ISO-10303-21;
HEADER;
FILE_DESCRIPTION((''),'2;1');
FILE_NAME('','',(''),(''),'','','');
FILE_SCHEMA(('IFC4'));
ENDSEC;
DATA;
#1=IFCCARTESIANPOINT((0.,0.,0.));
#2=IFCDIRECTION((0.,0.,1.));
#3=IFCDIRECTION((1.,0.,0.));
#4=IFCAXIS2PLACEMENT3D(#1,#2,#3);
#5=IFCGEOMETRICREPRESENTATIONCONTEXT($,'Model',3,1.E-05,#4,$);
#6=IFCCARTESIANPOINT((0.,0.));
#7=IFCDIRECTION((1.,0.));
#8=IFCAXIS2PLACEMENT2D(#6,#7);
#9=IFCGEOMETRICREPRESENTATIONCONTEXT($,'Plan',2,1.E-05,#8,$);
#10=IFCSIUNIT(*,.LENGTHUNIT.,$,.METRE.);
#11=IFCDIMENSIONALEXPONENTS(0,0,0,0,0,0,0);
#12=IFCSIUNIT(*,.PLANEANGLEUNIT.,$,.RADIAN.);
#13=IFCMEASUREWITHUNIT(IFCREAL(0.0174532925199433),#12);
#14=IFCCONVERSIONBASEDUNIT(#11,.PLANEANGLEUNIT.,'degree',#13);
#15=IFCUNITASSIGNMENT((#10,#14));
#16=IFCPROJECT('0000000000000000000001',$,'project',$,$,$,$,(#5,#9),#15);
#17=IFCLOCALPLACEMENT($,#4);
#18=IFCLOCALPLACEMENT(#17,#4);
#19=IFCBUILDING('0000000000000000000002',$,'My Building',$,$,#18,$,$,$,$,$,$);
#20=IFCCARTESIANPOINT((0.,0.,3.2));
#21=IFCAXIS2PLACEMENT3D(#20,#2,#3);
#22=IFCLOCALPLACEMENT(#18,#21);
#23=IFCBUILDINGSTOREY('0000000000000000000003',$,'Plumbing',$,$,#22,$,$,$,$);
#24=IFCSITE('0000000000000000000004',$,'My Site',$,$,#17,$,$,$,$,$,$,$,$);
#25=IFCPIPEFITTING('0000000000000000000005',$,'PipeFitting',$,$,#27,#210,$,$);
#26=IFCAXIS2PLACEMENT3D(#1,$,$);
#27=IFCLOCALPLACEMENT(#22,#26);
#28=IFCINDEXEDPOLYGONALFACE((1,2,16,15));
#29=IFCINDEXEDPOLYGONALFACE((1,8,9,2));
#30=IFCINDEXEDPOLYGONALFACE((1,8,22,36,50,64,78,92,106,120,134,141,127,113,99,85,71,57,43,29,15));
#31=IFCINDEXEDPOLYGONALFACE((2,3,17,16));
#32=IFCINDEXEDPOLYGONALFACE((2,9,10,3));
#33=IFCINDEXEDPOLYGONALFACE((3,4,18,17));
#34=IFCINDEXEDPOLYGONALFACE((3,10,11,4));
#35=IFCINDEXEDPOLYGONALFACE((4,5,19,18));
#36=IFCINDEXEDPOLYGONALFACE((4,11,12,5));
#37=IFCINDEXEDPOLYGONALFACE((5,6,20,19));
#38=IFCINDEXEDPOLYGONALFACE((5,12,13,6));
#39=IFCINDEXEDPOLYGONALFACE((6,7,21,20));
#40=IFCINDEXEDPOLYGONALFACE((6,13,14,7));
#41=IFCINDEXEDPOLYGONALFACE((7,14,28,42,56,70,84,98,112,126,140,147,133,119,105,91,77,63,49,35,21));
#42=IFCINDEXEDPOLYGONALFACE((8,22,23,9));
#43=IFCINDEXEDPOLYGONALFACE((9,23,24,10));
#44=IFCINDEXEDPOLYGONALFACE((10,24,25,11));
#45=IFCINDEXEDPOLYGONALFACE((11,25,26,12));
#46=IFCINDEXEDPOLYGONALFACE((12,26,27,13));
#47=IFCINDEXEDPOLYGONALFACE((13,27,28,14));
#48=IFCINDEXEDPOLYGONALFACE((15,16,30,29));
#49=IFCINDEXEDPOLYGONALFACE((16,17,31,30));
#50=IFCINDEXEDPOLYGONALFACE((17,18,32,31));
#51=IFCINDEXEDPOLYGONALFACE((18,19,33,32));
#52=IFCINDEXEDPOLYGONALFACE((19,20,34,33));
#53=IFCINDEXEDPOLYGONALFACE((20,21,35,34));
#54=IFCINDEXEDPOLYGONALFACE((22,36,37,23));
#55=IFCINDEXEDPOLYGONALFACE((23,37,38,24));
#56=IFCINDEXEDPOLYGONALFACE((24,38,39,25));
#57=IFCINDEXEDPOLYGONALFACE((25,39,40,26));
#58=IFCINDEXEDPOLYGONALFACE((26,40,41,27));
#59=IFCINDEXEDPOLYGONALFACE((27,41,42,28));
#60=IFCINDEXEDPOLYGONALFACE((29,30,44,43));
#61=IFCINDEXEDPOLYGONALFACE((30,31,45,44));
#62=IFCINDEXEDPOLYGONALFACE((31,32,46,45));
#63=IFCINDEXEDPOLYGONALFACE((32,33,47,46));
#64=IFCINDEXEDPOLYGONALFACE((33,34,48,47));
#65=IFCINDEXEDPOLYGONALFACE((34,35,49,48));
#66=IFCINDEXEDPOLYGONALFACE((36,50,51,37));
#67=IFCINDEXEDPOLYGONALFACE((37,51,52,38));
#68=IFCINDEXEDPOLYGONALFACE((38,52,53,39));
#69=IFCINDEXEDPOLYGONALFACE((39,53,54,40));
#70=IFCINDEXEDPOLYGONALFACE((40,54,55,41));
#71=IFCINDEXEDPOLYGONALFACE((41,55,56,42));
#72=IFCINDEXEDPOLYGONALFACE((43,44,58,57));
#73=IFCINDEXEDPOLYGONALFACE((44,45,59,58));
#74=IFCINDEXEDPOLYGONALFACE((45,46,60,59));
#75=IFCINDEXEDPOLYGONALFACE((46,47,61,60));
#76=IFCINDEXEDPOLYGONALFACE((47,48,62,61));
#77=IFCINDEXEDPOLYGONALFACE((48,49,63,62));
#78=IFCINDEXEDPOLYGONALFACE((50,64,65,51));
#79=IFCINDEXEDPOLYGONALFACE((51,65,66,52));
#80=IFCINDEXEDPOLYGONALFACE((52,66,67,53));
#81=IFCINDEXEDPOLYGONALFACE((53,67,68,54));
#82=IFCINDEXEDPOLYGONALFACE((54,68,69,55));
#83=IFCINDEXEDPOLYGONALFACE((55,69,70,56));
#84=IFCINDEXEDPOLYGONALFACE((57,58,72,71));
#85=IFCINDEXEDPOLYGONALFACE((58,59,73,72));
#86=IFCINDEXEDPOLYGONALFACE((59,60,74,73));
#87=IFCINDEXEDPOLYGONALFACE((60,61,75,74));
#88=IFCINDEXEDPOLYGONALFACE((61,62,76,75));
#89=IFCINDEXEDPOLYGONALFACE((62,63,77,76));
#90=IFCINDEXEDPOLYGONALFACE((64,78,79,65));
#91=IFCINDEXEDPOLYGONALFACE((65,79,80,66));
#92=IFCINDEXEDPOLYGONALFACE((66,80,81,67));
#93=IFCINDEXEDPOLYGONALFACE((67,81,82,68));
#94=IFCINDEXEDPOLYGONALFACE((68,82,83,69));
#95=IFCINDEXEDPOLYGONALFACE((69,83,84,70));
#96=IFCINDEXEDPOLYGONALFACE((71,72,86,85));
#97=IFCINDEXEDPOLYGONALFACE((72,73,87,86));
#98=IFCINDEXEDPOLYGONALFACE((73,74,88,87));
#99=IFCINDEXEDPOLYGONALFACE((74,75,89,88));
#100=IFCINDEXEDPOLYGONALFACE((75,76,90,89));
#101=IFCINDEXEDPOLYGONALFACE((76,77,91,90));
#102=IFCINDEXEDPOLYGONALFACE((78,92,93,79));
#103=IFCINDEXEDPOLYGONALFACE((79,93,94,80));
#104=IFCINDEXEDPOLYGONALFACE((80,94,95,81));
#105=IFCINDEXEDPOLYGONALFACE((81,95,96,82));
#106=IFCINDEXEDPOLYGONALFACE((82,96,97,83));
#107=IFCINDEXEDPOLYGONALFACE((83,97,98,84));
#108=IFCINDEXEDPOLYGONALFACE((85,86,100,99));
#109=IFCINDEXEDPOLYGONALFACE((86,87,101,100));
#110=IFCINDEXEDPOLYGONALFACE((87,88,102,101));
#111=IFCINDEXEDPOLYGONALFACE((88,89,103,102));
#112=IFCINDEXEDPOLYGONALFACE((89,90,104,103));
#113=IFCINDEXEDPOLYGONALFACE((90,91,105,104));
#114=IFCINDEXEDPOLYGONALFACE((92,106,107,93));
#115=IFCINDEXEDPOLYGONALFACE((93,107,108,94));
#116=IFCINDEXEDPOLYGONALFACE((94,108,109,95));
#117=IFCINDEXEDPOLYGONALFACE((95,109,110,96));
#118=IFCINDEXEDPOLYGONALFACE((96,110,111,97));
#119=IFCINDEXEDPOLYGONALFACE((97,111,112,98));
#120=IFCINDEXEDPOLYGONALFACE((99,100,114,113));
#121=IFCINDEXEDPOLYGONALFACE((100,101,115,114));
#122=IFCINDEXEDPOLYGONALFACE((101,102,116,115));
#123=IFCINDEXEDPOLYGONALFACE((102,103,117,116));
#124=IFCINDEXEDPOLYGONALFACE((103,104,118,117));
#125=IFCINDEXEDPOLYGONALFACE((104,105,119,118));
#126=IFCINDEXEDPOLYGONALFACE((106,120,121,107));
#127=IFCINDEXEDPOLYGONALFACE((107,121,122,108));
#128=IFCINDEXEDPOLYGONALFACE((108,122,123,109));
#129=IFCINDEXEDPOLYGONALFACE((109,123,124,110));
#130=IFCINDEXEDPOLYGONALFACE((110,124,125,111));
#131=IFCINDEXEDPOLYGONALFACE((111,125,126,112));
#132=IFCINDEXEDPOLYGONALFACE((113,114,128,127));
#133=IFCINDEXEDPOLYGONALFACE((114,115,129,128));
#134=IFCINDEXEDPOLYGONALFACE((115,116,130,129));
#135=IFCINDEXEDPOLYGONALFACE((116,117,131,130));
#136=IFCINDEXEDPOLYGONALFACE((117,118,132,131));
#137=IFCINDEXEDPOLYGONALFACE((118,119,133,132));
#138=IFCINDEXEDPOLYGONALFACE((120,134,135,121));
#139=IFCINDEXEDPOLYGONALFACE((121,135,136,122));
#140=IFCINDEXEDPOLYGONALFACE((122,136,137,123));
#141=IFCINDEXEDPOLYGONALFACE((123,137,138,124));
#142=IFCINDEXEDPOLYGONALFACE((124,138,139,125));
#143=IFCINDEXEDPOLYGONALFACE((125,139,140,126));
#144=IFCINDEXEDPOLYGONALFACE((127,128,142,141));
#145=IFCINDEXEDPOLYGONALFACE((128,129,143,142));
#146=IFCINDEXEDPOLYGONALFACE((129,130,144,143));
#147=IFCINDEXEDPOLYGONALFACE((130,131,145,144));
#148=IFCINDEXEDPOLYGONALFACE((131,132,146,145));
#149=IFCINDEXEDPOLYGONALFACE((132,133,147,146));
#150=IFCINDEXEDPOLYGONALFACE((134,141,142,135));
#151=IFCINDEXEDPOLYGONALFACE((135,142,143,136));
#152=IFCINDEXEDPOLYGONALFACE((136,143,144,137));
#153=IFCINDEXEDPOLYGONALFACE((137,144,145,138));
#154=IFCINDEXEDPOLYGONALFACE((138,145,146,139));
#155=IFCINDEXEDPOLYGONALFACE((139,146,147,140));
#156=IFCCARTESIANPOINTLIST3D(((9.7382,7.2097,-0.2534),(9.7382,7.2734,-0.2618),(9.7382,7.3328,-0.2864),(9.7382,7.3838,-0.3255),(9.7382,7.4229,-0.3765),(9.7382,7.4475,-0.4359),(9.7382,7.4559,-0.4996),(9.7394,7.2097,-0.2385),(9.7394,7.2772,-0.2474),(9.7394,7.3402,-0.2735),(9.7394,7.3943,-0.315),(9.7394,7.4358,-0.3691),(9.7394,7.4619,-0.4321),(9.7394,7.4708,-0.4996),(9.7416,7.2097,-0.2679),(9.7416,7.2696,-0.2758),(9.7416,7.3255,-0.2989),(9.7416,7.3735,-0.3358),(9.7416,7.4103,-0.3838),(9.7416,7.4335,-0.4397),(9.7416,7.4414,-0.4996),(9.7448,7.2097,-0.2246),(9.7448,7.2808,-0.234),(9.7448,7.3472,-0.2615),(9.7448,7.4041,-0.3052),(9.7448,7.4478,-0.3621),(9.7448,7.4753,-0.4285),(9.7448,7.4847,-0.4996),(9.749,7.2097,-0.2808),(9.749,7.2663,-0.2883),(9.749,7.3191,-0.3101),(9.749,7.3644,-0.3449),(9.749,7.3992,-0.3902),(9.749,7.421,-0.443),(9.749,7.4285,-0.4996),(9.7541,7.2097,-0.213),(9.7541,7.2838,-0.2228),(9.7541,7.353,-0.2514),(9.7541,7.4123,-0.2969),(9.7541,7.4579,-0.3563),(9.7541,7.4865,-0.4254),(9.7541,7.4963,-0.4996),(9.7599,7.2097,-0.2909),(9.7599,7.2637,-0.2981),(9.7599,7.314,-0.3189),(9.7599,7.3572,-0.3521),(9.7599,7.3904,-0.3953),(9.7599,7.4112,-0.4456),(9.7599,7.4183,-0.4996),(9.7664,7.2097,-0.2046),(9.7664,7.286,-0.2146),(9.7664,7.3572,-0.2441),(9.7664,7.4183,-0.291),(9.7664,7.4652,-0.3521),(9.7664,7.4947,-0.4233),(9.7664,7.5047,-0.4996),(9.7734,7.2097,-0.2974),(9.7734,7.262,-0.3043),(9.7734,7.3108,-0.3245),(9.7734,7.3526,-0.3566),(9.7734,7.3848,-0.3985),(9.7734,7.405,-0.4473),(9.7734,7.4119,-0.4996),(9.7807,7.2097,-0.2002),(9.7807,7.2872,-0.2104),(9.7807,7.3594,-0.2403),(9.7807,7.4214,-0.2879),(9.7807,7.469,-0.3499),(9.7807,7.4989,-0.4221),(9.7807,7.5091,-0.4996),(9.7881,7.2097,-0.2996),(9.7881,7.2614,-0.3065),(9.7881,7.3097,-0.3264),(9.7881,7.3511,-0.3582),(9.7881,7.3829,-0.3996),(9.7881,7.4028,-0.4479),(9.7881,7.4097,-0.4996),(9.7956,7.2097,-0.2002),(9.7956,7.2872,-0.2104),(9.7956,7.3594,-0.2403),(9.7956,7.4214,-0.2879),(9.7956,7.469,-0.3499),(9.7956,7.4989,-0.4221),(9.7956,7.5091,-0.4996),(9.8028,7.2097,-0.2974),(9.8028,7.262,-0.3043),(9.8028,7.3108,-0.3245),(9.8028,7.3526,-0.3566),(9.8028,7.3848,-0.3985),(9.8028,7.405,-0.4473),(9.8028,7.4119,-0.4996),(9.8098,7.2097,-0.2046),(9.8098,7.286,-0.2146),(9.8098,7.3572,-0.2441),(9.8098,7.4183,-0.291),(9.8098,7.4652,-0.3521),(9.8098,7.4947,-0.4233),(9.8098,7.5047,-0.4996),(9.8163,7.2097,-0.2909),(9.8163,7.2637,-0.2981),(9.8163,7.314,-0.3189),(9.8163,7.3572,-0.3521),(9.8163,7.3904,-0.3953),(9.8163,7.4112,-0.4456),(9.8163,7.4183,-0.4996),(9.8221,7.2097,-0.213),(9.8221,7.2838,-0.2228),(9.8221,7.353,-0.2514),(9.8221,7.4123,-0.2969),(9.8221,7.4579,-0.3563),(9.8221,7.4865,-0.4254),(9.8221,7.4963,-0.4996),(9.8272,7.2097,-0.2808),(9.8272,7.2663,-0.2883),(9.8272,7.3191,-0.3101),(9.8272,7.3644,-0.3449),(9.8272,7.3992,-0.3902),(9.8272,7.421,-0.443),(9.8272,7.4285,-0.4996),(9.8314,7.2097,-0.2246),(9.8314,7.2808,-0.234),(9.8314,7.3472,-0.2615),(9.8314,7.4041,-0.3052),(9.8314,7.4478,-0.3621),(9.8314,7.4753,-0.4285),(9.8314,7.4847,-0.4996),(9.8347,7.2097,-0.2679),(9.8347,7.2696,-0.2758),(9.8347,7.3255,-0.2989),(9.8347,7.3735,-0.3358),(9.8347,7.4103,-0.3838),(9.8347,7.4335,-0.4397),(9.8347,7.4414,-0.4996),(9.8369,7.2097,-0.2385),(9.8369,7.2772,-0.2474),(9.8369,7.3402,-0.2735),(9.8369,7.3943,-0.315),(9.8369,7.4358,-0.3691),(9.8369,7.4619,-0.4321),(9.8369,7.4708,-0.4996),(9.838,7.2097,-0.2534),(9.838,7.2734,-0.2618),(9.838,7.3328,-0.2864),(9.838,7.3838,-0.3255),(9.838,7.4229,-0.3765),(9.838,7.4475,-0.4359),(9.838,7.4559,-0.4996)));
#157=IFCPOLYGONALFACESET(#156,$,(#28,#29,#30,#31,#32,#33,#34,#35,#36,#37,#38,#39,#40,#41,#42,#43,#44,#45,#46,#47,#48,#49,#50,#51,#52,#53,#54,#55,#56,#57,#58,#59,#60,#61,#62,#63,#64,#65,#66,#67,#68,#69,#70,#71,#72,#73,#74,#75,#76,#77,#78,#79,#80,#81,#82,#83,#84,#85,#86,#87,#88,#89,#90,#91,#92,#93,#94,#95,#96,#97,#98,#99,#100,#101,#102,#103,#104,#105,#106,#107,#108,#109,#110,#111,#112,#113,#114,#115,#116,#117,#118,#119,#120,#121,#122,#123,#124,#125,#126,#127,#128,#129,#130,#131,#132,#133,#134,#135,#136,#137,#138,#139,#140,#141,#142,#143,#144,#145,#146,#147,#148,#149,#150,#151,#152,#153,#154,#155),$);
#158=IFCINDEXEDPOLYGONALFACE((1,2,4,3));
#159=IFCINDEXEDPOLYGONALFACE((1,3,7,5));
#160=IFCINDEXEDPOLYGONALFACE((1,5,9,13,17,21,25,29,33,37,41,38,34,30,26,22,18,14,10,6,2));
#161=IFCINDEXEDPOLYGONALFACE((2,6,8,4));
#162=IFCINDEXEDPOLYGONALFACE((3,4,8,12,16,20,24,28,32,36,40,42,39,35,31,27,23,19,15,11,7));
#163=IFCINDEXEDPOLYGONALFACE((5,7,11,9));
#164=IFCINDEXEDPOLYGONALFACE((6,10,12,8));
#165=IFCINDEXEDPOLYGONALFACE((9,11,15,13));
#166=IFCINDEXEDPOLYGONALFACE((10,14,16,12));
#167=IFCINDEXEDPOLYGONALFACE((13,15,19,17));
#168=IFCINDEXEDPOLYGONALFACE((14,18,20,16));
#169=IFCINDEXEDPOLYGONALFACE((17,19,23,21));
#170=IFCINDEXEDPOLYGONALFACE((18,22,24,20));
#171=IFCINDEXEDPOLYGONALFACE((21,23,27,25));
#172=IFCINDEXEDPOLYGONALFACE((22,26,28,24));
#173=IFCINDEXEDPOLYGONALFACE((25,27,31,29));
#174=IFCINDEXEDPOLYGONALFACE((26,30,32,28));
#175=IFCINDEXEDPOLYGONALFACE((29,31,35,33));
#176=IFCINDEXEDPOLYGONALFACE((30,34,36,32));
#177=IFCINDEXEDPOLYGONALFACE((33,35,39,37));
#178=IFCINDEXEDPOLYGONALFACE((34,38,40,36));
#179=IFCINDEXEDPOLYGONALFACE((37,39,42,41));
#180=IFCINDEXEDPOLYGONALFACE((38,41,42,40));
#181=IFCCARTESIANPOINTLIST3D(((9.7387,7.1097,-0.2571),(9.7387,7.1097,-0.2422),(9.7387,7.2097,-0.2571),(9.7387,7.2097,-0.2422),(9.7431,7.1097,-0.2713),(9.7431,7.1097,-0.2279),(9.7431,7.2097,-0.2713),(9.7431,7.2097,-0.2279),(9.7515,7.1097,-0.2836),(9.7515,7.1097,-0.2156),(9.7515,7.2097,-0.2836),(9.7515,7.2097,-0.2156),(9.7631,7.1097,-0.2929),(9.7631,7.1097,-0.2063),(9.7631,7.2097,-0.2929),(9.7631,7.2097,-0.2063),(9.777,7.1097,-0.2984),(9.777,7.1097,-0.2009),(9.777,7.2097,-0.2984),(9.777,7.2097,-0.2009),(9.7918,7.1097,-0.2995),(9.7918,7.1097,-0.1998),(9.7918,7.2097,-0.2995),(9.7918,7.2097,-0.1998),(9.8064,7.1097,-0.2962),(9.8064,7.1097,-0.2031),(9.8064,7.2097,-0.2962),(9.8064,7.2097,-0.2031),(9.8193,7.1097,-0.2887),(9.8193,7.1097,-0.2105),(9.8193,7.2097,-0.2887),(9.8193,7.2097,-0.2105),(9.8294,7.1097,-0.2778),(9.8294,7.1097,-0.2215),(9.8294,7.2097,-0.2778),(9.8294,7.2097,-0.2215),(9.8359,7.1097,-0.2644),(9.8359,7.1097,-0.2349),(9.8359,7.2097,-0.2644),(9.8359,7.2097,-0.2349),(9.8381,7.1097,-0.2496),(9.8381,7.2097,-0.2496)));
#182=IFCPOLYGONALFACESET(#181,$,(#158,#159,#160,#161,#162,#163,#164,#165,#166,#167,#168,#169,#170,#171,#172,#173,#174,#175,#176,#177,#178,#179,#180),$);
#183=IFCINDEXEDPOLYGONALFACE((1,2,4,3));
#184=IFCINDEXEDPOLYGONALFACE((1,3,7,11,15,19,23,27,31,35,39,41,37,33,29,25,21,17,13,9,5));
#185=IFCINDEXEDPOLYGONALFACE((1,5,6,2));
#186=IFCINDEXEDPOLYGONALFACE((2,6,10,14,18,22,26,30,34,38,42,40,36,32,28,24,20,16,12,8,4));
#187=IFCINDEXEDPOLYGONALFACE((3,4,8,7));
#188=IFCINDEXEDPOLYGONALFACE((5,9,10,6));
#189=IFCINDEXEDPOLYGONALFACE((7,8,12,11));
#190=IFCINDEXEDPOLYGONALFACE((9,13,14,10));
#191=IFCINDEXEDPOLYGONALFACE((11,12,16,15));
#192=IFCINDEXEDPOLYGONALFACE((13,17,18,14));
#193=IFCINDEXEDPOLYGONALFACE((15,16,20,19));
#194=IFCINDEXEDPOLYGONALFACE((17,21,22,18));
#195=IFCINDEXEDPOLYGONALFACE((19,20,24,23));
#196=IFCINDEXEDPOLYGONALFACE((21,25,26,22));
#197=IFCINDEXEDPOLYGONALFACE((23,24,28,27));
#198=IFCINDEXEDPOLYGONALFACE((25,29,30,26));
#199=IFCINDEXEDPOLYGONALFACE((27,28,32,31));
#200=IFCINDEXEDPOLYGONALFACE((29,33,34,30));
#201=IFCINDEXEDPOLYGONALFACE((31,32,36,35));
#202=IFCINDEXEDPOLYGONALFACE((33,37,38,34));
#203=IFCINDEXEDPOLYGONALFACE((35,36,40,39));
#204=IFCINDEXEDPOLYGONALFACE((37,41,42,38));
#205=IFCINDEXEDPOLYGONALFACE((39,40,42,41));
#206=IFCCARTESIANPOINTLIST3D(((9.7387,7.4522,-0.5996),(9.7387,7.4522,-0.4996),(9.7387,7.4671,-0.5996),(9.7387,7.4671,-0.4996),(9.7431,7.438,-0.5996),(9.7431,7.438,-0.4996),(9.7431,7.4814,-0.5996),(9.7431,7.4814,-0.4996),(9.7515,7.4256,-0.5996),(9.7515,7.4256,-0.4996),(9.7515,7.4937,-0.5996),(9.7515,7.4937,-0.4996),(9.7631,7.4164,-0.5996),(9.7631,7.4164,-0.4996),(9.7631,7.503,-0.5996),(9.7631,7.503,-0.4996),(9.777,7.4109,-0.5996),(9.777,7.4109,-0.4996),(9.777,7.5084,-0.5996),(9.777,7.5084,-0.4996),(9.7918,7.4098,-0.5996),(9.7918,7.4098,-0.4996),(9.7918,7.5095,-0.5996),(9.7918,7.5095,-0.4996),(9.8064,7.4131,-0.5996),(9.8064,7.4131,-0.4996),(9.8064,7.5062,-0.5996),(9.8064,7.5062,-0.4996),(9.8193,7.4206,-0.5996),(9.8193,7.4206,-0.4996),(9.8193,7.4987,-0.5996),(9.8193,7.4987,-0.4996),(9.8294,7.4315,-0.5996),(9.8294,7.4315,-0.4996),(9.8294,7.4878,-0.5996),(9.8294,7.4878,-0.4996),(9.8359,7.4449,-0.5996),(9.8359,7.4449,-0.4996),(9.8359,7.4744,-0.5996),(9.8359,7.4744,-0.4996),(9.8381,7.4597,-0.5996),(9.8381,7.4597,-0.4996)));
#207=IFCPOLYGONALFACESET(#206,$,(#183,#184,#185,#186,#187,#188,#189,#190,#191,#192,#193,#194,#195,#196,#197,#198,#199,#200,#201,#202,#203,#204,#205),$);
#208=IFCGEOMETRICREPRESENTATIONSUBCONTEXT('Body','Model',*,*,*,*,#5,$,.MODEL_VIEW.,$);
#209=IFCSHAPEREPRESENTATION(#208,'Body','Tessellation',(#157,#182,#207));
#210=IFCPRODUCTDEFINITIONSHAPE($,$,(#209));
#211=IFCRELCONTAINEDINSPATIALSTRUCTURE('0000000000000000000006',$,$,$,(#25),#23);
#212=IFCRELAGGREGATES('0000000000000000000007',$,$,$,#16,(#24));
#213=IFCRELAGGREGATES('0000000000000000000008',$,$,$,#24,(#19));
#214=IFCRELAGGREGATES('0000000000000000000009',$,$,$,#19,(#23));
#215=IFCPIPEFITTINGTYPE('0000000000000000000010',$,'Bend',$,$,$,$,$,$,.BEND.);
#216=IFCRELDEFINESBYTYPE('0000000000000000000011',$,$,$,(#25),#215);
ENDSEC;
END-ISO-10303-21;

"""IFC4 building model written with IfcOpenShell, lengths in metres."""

from ifc_helpers import new_model, entity, si_unit, converted_unit, frame, origin_with_axes, origin_2d_with_axis, place, context, subcontext, project, spatial, circle, extrude, source, transform, mapped, type_object, type_shapes, element, save


model = new_model("IFC4")

# Units and contexts
model_context = context("Model", 3, precision=1e-05, world=origin_with_axes())
plan_context = context("Plan", 2, precision=1e-05, world=origin_2d_with_axis())
body_context = subcontext(model_context, "Body", "Model", "MODEL_VIEW")
ifc_project = project(units=[si_unit("LENGTHUNIT", "METRE"), converted_unit("PLANEANGLEUNIT", "degree", entity("IfcReal", 0.0174532925199433), si_unit("PLANEANGLEUNIT", "RADIAN"), dimensions=[0, 0, 0, 0, 0, 0, 0])], contexts=[model_context, plan_context])

# Site, building, storey
site_placement = place(None, origin_with_axes())
site = spatial("IfcSite", under=ifc_project, at=site_placement, Name="My Site")
building_placement = place(site_placement, origin_with_axes())
building = spatial("IfcBuilding", under=site, at=building_placement, Name="My Building")
storey_placement = place(building_placement, frame((0.0, 0.0, 3.2), z_axis=(0.0, 0.0, 1.0), x_axis=(1.0, 0.0, 0.0)))
storey = spatial("IfcBuildingStorey", under=building, at=storey_placement, Name="Plumbing")

# Pipe fitting
pipe_fitting_type = type_object("IfcPipeFittingType", Name="Bend", PredefinedType="BEND")
shared_shape = source(origin_with_axes(), body_context, "Body", "SolidModel", [
    entity("IfcSweptDiskSolid", entity("IfcIndexedPolyCurve", entity("IfcCartesianPointList3D", [[0.0, 0.0, -0.1], [0.0, -0.0732, -0.2768], [0.0, -0.25, -0.35]]), [entity("IfcArcIndex", [1, 2, 3])]), 0.05),
    extrude(circle(Radius=0.05), origin_with_axes(), (0.0, 0.0, -1.0), 0.1),
    extrude(circle(Radius=0.05), frame((0.0, -0.25, -0.35), z_axis=(0.0, -1.0, 0.0), x_axis=(1.0, 0.0, 0.0)), (0.0, 0.0, 1.0), 0.1),
])
type_shapes(pipe_fitting_type, [shared_shape])
for number, where, z_axis, x_axis, name in (
    (1, (9.7881, 7.1097, -0.2496), (0.0, -1.0, 0.0), (1.0, 0.0, 0.0), "PipeFitting"),
):
    element("IfcPipeFitting", number, at=place(storey_placement, frame(where, z_axis=z_axis, x_axis=x_axis)), inside=storey, type_object=pipe_fitting_type, Name=name, context=body_context, shape_type="MappedRepresentation", body=[
        mapped(shared_shape, transform((0.0, 0.0, 0.0), x_axis=(1.0, 0.0, 0.0), y_axis=(0.0, 1.0, 0.0), z_axis=(0.0, 0.0, 1.0), scale=1.0)),
    ])

save(model, "model.ifc")
